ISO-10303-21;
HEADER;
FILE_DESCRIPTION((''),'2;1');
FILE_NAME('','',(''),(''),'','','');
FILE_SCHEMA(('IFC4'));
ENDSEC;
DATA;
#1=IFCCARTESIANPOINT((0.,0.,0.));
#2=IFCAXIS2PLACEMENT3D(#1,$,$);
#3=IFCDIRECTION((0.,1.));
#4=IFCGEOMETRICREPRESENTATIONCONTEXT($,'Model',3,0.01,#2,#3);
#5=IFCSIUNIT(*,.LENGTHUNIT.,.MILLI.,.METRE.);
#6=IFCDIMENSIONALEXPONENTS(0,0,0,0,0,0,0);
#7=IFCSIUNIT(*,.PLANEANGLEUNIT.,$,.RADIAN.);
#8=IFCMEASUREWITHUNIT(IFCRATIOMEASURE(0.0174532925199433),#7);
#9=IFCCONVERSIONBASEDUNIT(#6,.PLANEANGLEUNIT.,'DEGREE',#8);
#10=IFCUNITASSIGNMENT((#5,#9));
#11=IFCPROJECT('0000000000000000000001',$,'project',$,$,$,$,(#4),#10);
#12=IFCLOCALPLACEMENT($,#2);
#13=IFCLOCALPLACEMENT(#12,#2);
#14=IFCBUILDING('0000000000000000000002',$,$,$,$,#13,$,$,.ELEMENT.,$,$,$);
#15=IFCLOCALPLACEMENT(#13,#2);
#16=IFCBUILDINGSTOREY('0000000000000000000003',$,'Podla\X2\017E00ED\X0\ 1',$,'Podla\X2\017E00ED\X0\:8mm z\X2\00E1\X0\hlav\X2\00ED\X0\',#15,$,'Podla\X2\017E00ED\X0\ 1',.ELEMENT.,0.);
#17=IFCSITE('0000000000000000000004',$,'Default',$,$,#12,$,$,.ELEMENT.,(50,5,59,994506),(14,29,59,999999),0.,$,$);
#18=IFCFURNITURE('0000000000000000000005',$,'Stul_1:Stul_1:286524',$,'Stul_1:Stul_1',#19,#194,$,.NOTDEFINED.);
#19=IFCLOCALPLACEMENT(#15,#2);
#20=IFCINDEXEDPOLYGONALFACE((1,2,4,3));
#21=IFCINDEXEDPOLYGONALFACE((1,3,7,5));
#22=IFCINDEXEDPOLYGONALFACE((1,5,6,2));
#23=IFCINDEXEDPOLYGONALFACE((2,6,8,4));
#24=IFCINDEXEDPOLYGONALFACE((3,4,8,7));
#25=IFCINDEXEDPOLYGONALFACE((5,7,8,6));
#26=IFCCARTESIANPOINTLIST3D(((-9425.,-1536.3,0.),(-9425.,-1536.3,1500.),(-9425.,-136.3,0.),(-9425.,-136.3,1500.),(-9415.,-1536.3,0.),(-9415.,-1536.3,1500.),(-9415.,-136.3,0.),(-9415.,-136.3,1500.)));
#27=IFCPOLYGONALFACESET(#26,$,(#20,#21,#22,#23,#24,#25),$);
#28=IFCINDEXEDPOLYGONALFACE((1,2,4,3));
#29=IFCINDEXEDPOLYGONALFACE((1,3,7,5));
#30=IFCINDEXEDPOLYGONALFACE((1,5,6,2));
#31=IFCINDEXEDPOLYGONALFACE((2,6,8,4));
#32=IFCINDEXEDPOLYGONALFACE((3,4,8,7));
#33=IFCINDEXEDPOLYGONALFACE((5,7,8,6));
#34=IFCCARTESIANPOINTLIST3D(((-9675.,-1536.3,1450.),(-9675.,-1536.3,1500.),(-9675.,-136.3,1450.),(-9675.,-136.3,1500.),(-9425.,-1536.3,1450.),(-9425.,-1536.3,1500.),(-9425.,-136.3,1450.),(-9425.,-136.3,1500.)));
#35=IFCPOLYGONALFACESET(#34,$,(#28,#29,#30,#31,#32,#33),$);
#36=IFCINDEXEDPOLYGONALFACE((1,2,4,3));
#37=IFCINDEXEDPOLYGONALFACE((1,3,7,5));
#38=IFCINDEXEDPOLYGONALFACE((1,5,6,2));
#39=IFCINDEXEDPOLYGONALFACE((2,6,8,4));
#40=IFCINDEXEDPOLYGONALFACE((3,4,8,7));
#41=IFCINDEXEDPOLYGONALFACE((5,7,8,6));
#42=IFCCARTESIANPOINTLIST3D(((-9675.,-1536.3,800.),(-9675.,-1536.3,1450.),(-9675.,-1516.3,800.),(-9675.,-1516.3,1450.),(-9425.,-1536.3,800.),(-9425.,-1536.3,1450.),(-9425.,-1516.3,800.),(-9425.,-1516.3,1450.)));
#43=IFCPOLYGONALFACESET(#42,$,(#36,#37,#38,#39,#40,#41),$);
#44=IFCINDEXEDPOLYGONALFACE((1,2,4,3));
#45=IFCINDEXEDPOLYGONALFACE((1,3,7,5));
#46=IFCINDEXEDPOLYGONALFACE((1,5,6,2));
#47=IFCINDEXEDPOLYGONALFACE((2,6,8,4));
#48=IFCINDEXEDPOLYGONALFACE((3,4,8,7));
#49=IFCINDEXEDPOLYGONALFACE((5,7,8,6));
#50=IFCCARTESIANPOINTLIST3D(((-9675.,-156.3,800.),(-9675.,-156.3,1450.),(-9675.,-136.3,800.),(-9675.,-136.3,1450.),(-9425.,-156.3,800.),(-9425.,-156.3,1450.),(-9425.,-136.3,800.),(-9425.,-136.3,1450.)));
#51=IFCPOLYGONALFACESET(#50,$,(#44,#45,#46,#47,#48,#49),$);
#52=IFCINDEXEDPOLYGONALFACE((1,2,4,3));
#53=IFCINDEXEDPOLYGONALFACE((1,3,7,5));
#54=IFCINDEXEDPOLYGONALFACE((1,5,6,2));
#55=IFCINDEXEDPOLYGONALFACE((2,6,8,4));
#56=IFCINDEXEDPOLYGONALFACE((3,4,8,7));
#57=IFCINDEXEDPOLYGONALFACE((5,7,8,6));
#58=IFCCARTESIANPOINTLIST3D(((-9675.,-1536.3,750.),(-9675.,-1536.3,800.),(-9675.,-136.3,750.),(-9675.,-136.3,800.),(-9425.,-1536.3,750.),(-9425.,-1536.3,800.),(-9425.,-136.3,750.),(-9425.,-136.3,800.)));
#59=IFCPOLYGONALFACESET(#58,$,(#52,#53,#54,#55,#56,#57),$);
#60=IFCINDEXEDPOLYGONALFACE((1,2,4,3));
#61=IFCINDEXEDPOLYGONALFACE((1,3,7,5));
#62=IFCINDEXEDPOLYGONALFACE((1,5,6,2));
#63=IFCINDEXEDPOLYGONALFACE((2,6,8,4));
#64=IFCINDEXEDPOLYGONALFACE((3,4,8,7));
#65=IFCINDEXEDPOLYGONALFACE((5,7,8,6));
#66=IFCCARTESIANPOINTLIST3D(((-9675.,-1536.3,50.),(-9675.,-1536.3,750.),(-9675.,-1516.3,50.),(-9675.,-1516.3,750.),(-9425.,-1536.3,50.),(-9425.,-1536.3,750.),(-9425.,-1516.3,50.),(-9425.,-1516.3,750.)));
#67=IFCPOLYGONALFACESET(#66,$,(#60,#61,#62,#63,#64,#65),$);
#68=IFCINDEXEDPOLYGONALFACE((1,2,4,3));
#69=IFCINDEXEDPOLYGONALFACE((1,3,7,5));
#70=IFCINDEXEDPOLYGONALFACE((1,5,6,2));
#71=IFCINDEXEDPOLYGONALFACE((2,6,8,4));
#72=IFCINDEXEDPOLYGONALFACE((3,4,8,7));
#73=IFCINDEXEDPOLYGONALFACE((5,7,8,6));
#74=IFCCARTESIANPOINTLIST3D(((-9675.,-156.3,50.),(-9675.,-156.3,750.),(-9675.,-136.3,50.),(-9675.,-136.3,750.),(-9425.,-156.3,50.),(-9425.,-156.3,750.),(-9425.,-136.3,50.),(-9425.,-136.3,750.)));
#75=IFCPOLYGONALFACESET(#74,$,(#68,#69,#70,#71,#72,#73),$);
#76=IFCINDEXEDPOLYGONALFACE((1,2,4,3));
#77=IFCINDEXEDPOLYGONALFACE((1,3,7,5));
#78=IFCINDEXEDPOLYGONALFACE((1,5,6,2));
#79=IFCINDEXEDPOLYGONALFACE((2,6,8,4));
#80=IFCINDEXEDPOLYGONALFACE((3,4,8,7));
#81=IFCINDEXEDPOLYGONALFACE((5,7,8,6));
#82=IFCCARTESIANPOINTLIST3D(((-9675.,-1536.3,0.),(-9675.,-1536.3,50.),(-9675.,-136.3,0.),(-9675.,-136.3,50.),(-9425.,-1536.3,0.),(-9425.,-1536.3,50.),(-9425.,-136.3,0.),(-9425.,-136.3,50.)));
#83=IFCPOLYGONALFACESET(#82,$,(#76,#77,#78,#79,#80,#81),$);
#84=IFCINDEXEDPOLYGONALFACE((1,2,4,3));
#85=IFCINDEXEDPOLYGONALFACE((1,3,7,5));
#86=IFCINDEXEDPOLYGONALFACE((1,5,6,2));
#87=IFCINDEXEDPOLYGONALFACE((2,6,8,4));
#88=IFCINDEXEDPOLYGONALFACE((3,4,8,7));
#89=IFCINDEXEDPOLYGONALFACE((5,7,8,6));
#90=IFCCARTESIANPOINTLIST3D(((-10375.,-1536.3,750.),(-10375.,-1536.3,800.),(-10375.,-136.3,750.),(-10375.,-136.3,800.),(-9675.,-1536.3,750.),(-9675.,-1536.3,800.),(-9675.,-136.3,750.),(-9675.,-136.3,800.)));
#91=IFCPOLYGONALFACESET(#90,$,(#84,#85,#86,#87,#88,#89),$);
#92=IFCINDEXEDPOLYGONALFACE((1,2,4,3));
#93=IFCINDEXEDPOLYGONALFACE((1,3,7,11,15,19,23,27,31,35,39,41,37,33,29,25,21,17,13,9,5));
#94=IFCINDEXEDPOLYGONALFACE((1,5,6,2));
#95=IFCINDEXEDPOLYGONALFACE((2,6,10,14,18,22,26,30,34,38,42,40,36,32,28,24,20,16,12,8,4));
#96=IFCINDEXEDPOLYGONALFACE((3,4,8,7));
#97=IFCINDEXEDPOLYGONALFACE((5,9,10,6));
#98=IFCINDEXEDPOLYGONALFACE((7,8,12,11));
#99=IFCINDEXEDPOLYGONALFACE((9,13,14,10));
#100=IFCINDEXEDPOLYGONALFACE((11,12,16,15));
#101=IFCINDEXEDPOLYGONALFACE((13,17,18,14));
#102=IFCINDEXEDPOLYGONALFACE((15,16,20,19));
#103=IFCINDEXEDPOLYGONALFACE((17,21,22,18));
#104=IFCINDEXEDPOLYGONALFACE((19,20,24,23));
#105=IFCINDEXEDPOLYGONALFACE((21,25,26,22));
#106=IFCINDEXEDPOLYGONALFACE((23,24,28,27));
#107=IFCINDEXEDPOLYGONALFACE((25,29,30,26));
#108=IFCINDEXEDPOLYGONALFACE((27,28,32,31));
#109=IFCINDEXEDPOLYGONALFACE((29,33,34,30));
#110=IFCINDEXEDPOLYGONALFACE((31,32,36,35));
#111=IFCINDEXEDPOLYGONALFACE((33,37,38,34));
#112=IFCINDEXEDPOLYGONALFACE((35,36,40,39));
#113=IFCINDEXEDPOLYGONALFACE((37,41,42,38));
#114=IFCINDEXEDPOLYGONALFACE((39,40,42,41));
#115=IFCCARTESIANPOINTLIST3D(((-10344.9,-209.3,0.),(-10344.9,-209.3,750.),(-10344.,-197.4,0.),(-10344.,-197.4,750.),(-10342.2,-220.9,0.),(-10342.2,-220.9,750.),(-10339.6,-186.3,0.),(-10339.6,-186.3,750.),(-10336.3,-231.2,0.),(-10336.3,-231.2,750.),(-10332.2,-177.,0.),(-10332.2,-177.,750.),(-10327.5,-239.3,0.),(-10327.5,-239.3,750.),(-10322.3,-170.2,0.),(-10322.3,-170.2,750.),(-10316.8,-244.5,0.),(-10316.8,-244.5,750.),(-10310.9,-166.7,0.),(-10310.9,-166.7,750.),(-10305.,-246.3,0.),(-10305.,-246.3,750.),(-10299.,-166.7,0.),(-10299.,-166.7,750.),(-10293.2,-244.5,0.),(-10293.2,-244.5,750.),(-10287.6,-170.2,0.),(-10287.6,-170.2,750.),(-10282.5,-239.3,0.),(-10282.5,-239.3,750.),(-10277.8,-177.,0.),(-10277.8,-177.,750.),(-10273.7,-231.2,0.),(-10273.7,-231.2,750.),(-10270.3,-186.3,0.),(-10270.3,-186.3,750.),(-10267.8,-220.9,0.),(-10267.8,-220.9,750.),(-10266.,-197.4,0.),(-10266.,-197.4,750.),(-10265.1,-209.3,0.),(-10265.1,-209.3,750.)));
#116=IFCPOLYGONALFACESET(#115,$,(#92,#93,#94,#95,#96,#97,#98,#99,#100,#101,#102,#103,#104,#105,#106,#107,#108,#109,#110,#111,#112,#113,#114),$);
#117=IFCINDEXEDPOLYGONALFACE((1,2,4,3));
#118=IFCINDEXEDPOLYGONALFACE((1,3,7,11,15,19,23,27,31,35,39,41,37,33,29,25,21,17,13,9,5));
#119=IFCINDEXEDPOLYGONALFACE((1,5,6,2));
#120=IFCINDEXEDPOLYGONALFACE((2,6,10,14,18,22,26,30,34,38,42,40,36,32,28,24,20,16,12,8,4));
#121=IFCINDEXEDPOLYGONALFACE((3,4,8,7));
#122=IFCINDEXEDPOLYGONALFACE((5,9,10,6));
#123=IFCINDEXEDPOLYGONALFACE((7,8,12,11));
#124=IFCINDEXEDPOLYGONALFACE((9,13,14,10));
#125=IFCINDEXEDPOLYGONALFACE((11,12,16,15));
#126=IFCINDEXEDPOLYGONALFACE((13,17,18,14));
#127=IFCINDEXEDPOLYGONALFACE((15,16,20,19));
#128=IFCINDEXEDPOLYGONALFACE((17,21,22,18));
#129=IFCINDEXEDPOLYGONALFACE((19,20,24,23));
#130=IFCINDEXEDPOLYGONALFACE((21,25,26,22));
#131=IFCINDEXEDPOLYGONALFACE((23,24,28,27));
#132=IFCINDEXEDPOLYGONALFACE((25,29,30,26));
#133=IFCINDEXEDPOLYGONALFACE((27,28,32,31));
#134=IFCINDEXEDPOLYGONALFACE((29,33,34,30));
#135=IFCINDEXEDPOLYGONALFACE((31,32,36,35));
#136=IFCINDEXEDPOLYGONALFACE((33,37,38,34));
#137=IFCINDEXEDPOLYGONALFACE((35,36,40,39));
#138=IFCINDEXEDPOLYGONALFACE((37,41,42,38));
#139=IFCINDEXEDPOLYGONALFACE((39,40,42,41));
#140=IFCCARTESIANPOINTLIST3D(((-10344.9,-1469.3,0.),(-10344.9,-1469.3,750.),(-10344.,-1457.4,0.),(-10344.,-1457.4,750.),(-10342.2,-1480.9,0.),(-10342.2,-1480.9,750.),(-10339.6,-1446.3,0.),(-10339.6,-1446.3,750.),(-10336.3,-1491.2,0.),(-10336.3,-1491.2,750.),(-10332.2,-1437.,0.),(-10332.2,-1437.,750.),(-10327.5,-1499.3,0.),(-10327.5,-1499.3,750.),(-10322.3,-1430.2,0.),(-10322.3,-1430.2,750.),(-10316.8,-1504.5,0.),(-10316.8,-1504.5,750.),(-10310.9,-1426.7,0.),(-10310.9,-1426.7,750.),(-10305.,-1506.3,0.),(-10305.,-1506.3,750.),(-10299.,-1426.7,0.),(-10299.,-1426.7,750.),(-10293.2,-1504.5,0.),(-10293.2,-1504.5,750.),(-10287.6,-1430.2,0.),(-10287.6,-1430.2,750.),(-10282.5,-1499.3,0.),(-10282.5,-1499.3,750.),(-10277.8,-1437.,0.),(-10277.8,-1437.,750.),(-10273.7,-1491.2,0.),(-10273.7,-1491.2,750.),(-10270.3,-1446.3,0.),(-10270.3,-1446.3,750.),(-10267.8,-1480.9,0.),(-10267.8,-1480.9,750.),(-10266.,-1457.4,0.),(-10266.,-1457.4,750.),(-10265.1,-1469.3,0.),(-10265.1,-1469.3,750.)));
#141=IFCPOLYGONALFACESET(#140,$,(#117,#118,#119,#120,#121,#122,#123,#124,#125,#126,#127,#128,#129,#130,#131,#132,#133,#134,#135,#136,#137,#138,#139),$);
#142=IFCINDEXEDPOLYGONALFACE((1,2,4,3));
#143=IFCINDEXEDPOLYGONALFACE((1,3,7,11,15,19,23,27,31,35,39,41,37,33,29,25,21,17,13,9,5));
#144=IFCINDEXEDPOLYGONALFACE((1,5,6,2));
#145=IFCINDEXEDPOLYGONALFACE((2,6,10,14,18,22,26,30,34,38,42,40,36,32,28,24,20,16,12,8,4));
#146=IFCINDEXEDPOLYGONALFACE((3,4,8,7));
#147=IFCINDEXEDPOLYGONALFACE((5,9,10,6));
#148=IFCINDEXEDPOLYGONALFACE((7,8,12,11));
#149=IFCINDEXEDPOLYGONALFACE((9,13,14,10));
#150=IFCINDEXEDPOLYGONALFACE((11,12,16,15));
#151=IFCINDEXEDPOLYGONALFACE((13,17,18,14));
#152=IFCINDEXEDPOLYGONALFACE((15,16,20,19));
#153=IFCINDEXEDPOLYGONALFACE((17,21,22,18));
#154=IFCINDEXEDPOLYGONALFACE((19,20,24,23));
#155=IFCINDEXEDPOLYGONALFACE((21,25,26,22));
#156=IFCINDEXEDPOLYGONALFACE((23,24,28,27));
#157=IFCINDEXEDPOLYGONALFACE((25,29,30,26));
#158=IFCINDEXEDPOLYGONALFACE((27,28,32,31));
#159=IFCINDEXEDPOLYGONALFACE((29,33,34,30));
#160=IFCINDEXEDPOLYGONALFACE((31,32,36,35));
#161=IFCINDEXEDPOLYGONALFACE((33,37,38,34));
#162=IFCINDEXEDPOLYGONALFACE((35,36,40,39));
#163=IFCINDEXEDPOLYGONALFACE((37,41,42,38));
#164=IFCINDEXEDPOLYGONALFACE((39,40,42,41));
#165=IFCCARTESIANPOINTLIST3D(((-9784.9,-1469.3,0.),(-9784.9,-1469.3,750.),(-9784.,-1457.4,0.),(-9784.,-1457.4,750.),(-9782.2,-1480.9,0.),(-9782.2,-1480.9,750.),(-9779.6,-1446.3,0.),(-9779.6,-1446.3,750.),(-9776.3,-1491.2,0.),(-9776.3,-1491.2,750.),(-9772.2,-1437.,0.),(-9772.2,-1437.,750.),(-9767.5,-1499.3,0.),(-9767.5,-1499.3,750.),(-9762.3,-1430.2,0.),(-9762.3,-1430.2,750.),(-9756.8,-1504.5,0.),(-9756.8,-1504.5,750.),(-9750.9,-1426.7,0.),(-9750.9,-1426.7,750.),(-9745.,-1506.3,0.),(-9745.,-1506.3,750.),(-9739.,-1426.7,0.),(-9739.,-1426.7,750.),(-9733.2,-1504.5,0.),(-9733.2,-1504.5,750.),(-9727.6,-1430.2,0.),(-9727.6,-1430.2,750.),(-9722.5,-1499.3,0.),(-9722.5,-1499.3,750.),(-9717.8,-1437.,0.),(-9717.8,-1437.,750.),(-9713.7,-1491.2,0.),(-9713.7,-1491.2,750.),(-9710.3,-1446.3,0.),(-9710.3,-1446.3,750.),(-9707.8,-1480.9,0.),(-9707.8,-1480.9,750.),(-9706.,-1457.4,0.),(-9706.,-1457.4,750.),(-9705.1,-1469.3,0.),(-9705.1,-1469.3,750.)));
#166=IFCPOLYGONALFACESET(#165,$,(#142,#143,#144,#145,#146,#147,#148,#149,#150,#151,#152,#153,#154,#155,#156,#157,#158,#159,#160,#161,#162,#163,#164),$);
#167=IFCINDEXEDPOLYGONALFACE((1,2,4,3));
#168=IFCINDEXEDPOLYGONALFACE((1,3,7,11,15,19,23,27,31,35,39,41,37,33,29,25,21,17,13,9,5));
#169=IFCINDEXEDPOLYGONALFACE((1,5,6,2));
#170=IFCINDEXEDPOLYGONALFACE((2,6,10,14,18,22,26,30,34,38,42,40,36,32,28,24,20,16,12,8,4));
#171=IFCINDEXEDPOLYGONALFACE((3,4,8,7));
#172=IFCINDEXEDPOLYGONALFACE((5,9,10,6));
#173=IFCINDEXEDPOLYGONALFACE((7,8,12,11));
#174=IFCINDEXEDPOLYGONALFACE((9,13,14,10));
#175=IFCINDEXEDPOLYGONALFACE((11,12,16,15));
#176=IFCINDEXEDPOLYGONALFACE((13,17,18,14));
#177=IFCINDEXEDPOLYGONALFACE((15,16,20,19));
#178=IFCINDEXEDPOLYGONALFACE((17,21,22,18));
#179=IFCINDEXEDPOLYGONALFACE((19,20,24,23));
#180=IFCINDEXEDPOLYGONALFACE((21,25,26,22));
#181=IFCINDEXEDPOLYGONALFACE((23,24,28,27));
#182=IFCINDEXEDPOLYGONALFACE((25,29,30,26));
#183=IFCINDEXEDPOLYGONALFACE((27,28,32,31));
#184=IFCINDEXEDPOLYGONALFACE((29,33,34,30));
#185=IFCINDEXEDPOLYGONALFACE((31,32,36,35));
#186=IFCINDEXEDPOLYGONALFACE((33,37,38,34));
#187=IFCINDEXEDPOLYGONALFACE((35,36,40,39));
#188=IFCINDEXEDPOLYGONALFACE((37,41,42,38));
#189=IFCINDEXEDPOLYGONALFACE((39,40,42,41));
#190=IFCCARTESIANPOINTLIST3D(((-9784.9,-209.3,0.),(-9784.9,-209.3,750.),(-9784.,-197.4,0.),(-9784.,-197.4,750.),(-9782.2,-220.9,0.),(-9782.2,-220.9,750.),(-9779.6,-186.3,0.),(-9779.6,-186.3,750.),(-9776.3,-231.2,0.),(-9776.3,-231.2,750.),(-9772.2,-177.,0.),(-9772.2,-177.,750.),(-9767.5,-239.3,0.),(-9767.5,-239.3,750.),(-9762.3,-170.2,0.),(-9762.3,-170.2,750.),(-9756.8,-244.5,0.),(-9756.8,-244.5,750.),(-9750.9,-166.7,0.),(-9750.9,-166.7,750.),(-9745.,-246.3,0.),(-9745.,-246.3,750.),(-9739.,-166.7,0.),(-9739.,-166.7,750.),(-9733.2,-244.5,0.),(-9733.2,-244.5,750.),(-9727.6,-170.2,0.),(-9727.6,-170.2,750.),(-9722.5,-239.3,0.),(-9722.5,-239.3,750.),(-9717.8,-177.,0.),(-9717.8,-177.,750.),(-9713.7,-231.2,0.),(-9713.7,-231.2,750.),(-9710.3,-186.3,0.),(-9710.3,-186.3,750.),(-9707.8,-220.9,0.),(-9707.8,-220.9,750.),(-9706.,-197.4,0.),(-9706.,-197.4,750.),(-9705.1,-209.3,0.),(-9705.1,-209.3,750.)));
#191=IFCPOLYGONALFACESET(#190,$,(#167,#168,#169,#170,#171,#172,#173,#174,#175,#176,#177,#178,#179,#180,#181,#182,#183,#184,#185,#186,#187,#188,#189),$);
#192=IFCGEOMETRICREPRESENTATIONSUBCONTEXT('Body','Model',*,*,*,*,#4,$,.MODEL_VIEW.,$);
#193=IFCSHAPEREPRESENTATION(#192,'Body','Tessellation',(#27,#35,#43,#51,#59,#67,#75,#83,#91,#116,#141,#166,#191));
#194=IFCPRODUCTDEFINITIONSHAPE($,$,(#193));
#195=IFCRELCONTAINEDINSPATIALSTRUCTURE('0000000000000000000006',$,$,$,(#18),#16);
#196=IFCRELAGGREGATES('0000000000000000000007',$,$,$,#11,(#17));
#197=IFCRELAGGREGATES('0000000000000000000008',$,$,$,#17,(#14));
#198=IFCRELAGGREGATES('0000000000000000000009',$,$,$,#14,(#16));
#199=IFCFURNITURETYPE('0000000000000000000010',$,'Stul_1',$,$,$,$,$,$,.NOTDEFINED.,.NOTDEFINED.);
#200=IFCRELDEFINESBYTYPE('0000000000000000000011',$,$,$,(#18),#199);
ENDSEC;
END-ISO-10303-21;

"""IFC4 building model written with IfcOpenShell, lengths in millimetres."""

from ifc_helpers import new_model, entity, si_unit, converted_unit, direction, frame, frame_2d, origin, origin_2d_with_axis, place, context, subcontext, project, spatial, rectangle, circle, extrude, source, transform, mapped, type_object, type_shapes, element, save


model = new_model("IFC4")

# Units and contexts
model_context = context("Model", 3, precision=0.01, world=origin(), true_north=direction((0.0, 1.0)))
body_context = subcontext(model_context, "Body", "Model", "MODEL_VIEW")
ifc_project = project(units=[si_unit("LENGTHUNIT", "METRE", prefix="MILLI"), converted_unit("PLANEANGLEUNIT", "DEGREE", entity("IfcRatioMeasure", 0.0174532925199433), si_unit("PLANEANGLEUNIT", "RADIAN"), dimensions=[0, 0, 0, 0, 0, 0, 0])], contexts=[model_context])

# Site, building, storey
site_placement = place(None, origin())
site = spatial("IfcSite", under=ifc_project, at=site_placement, Name="Default", CompositionType="ELEMENT", RefLatitude=(50, 5, 59, 994506), RefLongitude=(14, 29, 59, 999999), RefElevation=0.0)
building_placement = place(site_placement, origin())
building = spatial("IfcBuilding", under=site, at=building_placement, CompositionType="ELEMENT")
storey_placement = place(building_placement, origin())
storey = spatial("IfcBuildingStorey", under=building, at=storey_placement, Name="Podlaží 1", ObjectType="Podlaží:8mm záhlaví", LongName="Podlaží 1", CompositionType="ELEMENT", Elevation=0.0)

# Furniture
furniture_type = type_object("IfcFurnitureType", Name="Stul_1", AssemblyPlace="NOTDEFINED", PredefinedType="NOTDEFINED")
shared_shape_1 = source(origin(), body_context, "Body", "SweptSolid", [
    extrude(rectangle(XDim=1400.0, YDim=10.0, at=origin_2d_with_axis()), frame((0.0, 605.0, 0.0), z_axis=(0.0, 0.0, 1.0), x_axis=(-1.0, 0.0, 0.0)), (0.0, 0.0, 1.0), 1500.0),
    extrude(rectangle(XDim=1400.0, YDim=250.0, at=frame_2d((0.0, 0.0), x_axis=(1.0, 0.0))), frame((0.0, 475.0, 1450.0), z_axis=(0.0, 0.0, 1.0), x_axis=(-1.0, 0.0, 0.0)), (0.0, 0.0, 1.0), 50.0),
    extrude(rectangle(XDim=20.0, YDim=250.0, at=origin_2d_with_axis()), frame((690.0, 475.0, 800.0), z_axis=(0.0, 0.0, 1.0), x_axis=(-1.0, 0.0, 0.0)), (0.0, 0.0, 1.0), 650.0),
    extrude(rectangle(XDim=20.0, YDim=250.0, at=frame_2d((0.0, 0.0), x_axis=(1.0, 0.0))), frame((-690.0, 475.0, 800.0), z_axis=(0.0, 0.0, 1.0), x_axis=(-1.0, 0.0, 0.0)), (0.0, 0.0, 1.0), 650.0),
    extrude(rectangle(XDim=1400.0, YDim=250.0, at=origin_2d_with_axis()), frame((0.0, 475.0, 750.0), z_axis=(0.0, 0.0, 1.0), x_axis=(-1.0, 0.0, 0.0)), (0.0, 0.0, 1.0), 50.0),
    extrude(rectangle(XDim=20.0, YDim=250.0, at=origin_2d_with_axis()), frame((690.0, 475.0, 50.0), z_axis=(0.0, 0.0, 1.0), x_axis=(-1.0, 0.0, 0.0)), (0.0, 0.0, 1.0), 700.0),
    extrude(rectangle(XDim=20.0, YDim=250.0, at=frame_2d((0.0, 0.0), x_axis=(1.0, 0.0))), frame((-690.0, 475.0, 50.0), z_axis=(0.0, 0.0, 1.0), x_axis=(-1.0, 0.0, 0.0)), (0.0, 0.0, 1.0), 700.0),
    extrude(rectangle(XDim=1400.0, YDim=250.0, at=origin_2d_with_axis()), frame((0.0, 475.0, 0.0), z_axis=(0.0, 0.0, 1.0), x_axis=(-1.0, 0.0, 0.0)), (0.0, 0.0, 1.0), 50.0),
    extrude(rectangle(XDim=1400.0, YDim=700.0, at=origin_2d_with_axis()), frame((0.0, 0.0, 750.0), z_axis=(0.0, 0.0, 1.0), x_axis=(-1.0, 0.0, 0.0)), (0.0, 0.0, 1.0), 50.0),
    extrude(circle(Radius=40.0, at=frame_2d((0.0, 0.0), x_axis=(1.0, 0.0))), frame((-630.0, -280.0, 0.0)), (0.0, 0.0, 1.0), 750.0),
    extrude(circle(Radius=40.0, at=frame_2d((0.0, 0.0), x_axis=(1.0, 0.0))), frame((630.0, -280.0, 0.0)), (0.0, 0.0, 1.0), 750.0),
    extrude(circle(Radius=40.0, at=frame_2d((0.0, 0.0), x_axis=(1.0, 0.0))), frame((630.0, 280.0, 0.0)), (0.0, 0.0, 1.0), 750.0),
    extrude(circle(Radius=40.0, at=frame_2d((0.0, 0.0), x_axis=(1.0, 0.0))), frame((-630.0, 280.0, 0.0)), (0.0, 0.0, 1.0), 750.0),
])
type_shapes(furniture_type, [shared_shape_1])
for number, where, z_axis, x_axis, name in (
    (1, (-10025.0, -836.3, 0.0), (0.0, 0.0, 1.0), (0.0, -1.0, 0.0), "Stul_1:Stul_1:286524"),
):
    element("IfcFurniture", number, at=place(storey_placement, frame(where, z_axis=z_axis, x_axis=x_axis)), inside=storey, type_object=furniture_type, Name=name, ObjectType="Stul_1:Stul_1", PredefinedType="NOTDEFINED", context=body_context, shape_type="MappedRepresentation", body=[
        mapped(shared_shape_1, transform((0.0, 0.0, 0.0), scale=1.0)),
    ])

save(model, "model.ifc")
